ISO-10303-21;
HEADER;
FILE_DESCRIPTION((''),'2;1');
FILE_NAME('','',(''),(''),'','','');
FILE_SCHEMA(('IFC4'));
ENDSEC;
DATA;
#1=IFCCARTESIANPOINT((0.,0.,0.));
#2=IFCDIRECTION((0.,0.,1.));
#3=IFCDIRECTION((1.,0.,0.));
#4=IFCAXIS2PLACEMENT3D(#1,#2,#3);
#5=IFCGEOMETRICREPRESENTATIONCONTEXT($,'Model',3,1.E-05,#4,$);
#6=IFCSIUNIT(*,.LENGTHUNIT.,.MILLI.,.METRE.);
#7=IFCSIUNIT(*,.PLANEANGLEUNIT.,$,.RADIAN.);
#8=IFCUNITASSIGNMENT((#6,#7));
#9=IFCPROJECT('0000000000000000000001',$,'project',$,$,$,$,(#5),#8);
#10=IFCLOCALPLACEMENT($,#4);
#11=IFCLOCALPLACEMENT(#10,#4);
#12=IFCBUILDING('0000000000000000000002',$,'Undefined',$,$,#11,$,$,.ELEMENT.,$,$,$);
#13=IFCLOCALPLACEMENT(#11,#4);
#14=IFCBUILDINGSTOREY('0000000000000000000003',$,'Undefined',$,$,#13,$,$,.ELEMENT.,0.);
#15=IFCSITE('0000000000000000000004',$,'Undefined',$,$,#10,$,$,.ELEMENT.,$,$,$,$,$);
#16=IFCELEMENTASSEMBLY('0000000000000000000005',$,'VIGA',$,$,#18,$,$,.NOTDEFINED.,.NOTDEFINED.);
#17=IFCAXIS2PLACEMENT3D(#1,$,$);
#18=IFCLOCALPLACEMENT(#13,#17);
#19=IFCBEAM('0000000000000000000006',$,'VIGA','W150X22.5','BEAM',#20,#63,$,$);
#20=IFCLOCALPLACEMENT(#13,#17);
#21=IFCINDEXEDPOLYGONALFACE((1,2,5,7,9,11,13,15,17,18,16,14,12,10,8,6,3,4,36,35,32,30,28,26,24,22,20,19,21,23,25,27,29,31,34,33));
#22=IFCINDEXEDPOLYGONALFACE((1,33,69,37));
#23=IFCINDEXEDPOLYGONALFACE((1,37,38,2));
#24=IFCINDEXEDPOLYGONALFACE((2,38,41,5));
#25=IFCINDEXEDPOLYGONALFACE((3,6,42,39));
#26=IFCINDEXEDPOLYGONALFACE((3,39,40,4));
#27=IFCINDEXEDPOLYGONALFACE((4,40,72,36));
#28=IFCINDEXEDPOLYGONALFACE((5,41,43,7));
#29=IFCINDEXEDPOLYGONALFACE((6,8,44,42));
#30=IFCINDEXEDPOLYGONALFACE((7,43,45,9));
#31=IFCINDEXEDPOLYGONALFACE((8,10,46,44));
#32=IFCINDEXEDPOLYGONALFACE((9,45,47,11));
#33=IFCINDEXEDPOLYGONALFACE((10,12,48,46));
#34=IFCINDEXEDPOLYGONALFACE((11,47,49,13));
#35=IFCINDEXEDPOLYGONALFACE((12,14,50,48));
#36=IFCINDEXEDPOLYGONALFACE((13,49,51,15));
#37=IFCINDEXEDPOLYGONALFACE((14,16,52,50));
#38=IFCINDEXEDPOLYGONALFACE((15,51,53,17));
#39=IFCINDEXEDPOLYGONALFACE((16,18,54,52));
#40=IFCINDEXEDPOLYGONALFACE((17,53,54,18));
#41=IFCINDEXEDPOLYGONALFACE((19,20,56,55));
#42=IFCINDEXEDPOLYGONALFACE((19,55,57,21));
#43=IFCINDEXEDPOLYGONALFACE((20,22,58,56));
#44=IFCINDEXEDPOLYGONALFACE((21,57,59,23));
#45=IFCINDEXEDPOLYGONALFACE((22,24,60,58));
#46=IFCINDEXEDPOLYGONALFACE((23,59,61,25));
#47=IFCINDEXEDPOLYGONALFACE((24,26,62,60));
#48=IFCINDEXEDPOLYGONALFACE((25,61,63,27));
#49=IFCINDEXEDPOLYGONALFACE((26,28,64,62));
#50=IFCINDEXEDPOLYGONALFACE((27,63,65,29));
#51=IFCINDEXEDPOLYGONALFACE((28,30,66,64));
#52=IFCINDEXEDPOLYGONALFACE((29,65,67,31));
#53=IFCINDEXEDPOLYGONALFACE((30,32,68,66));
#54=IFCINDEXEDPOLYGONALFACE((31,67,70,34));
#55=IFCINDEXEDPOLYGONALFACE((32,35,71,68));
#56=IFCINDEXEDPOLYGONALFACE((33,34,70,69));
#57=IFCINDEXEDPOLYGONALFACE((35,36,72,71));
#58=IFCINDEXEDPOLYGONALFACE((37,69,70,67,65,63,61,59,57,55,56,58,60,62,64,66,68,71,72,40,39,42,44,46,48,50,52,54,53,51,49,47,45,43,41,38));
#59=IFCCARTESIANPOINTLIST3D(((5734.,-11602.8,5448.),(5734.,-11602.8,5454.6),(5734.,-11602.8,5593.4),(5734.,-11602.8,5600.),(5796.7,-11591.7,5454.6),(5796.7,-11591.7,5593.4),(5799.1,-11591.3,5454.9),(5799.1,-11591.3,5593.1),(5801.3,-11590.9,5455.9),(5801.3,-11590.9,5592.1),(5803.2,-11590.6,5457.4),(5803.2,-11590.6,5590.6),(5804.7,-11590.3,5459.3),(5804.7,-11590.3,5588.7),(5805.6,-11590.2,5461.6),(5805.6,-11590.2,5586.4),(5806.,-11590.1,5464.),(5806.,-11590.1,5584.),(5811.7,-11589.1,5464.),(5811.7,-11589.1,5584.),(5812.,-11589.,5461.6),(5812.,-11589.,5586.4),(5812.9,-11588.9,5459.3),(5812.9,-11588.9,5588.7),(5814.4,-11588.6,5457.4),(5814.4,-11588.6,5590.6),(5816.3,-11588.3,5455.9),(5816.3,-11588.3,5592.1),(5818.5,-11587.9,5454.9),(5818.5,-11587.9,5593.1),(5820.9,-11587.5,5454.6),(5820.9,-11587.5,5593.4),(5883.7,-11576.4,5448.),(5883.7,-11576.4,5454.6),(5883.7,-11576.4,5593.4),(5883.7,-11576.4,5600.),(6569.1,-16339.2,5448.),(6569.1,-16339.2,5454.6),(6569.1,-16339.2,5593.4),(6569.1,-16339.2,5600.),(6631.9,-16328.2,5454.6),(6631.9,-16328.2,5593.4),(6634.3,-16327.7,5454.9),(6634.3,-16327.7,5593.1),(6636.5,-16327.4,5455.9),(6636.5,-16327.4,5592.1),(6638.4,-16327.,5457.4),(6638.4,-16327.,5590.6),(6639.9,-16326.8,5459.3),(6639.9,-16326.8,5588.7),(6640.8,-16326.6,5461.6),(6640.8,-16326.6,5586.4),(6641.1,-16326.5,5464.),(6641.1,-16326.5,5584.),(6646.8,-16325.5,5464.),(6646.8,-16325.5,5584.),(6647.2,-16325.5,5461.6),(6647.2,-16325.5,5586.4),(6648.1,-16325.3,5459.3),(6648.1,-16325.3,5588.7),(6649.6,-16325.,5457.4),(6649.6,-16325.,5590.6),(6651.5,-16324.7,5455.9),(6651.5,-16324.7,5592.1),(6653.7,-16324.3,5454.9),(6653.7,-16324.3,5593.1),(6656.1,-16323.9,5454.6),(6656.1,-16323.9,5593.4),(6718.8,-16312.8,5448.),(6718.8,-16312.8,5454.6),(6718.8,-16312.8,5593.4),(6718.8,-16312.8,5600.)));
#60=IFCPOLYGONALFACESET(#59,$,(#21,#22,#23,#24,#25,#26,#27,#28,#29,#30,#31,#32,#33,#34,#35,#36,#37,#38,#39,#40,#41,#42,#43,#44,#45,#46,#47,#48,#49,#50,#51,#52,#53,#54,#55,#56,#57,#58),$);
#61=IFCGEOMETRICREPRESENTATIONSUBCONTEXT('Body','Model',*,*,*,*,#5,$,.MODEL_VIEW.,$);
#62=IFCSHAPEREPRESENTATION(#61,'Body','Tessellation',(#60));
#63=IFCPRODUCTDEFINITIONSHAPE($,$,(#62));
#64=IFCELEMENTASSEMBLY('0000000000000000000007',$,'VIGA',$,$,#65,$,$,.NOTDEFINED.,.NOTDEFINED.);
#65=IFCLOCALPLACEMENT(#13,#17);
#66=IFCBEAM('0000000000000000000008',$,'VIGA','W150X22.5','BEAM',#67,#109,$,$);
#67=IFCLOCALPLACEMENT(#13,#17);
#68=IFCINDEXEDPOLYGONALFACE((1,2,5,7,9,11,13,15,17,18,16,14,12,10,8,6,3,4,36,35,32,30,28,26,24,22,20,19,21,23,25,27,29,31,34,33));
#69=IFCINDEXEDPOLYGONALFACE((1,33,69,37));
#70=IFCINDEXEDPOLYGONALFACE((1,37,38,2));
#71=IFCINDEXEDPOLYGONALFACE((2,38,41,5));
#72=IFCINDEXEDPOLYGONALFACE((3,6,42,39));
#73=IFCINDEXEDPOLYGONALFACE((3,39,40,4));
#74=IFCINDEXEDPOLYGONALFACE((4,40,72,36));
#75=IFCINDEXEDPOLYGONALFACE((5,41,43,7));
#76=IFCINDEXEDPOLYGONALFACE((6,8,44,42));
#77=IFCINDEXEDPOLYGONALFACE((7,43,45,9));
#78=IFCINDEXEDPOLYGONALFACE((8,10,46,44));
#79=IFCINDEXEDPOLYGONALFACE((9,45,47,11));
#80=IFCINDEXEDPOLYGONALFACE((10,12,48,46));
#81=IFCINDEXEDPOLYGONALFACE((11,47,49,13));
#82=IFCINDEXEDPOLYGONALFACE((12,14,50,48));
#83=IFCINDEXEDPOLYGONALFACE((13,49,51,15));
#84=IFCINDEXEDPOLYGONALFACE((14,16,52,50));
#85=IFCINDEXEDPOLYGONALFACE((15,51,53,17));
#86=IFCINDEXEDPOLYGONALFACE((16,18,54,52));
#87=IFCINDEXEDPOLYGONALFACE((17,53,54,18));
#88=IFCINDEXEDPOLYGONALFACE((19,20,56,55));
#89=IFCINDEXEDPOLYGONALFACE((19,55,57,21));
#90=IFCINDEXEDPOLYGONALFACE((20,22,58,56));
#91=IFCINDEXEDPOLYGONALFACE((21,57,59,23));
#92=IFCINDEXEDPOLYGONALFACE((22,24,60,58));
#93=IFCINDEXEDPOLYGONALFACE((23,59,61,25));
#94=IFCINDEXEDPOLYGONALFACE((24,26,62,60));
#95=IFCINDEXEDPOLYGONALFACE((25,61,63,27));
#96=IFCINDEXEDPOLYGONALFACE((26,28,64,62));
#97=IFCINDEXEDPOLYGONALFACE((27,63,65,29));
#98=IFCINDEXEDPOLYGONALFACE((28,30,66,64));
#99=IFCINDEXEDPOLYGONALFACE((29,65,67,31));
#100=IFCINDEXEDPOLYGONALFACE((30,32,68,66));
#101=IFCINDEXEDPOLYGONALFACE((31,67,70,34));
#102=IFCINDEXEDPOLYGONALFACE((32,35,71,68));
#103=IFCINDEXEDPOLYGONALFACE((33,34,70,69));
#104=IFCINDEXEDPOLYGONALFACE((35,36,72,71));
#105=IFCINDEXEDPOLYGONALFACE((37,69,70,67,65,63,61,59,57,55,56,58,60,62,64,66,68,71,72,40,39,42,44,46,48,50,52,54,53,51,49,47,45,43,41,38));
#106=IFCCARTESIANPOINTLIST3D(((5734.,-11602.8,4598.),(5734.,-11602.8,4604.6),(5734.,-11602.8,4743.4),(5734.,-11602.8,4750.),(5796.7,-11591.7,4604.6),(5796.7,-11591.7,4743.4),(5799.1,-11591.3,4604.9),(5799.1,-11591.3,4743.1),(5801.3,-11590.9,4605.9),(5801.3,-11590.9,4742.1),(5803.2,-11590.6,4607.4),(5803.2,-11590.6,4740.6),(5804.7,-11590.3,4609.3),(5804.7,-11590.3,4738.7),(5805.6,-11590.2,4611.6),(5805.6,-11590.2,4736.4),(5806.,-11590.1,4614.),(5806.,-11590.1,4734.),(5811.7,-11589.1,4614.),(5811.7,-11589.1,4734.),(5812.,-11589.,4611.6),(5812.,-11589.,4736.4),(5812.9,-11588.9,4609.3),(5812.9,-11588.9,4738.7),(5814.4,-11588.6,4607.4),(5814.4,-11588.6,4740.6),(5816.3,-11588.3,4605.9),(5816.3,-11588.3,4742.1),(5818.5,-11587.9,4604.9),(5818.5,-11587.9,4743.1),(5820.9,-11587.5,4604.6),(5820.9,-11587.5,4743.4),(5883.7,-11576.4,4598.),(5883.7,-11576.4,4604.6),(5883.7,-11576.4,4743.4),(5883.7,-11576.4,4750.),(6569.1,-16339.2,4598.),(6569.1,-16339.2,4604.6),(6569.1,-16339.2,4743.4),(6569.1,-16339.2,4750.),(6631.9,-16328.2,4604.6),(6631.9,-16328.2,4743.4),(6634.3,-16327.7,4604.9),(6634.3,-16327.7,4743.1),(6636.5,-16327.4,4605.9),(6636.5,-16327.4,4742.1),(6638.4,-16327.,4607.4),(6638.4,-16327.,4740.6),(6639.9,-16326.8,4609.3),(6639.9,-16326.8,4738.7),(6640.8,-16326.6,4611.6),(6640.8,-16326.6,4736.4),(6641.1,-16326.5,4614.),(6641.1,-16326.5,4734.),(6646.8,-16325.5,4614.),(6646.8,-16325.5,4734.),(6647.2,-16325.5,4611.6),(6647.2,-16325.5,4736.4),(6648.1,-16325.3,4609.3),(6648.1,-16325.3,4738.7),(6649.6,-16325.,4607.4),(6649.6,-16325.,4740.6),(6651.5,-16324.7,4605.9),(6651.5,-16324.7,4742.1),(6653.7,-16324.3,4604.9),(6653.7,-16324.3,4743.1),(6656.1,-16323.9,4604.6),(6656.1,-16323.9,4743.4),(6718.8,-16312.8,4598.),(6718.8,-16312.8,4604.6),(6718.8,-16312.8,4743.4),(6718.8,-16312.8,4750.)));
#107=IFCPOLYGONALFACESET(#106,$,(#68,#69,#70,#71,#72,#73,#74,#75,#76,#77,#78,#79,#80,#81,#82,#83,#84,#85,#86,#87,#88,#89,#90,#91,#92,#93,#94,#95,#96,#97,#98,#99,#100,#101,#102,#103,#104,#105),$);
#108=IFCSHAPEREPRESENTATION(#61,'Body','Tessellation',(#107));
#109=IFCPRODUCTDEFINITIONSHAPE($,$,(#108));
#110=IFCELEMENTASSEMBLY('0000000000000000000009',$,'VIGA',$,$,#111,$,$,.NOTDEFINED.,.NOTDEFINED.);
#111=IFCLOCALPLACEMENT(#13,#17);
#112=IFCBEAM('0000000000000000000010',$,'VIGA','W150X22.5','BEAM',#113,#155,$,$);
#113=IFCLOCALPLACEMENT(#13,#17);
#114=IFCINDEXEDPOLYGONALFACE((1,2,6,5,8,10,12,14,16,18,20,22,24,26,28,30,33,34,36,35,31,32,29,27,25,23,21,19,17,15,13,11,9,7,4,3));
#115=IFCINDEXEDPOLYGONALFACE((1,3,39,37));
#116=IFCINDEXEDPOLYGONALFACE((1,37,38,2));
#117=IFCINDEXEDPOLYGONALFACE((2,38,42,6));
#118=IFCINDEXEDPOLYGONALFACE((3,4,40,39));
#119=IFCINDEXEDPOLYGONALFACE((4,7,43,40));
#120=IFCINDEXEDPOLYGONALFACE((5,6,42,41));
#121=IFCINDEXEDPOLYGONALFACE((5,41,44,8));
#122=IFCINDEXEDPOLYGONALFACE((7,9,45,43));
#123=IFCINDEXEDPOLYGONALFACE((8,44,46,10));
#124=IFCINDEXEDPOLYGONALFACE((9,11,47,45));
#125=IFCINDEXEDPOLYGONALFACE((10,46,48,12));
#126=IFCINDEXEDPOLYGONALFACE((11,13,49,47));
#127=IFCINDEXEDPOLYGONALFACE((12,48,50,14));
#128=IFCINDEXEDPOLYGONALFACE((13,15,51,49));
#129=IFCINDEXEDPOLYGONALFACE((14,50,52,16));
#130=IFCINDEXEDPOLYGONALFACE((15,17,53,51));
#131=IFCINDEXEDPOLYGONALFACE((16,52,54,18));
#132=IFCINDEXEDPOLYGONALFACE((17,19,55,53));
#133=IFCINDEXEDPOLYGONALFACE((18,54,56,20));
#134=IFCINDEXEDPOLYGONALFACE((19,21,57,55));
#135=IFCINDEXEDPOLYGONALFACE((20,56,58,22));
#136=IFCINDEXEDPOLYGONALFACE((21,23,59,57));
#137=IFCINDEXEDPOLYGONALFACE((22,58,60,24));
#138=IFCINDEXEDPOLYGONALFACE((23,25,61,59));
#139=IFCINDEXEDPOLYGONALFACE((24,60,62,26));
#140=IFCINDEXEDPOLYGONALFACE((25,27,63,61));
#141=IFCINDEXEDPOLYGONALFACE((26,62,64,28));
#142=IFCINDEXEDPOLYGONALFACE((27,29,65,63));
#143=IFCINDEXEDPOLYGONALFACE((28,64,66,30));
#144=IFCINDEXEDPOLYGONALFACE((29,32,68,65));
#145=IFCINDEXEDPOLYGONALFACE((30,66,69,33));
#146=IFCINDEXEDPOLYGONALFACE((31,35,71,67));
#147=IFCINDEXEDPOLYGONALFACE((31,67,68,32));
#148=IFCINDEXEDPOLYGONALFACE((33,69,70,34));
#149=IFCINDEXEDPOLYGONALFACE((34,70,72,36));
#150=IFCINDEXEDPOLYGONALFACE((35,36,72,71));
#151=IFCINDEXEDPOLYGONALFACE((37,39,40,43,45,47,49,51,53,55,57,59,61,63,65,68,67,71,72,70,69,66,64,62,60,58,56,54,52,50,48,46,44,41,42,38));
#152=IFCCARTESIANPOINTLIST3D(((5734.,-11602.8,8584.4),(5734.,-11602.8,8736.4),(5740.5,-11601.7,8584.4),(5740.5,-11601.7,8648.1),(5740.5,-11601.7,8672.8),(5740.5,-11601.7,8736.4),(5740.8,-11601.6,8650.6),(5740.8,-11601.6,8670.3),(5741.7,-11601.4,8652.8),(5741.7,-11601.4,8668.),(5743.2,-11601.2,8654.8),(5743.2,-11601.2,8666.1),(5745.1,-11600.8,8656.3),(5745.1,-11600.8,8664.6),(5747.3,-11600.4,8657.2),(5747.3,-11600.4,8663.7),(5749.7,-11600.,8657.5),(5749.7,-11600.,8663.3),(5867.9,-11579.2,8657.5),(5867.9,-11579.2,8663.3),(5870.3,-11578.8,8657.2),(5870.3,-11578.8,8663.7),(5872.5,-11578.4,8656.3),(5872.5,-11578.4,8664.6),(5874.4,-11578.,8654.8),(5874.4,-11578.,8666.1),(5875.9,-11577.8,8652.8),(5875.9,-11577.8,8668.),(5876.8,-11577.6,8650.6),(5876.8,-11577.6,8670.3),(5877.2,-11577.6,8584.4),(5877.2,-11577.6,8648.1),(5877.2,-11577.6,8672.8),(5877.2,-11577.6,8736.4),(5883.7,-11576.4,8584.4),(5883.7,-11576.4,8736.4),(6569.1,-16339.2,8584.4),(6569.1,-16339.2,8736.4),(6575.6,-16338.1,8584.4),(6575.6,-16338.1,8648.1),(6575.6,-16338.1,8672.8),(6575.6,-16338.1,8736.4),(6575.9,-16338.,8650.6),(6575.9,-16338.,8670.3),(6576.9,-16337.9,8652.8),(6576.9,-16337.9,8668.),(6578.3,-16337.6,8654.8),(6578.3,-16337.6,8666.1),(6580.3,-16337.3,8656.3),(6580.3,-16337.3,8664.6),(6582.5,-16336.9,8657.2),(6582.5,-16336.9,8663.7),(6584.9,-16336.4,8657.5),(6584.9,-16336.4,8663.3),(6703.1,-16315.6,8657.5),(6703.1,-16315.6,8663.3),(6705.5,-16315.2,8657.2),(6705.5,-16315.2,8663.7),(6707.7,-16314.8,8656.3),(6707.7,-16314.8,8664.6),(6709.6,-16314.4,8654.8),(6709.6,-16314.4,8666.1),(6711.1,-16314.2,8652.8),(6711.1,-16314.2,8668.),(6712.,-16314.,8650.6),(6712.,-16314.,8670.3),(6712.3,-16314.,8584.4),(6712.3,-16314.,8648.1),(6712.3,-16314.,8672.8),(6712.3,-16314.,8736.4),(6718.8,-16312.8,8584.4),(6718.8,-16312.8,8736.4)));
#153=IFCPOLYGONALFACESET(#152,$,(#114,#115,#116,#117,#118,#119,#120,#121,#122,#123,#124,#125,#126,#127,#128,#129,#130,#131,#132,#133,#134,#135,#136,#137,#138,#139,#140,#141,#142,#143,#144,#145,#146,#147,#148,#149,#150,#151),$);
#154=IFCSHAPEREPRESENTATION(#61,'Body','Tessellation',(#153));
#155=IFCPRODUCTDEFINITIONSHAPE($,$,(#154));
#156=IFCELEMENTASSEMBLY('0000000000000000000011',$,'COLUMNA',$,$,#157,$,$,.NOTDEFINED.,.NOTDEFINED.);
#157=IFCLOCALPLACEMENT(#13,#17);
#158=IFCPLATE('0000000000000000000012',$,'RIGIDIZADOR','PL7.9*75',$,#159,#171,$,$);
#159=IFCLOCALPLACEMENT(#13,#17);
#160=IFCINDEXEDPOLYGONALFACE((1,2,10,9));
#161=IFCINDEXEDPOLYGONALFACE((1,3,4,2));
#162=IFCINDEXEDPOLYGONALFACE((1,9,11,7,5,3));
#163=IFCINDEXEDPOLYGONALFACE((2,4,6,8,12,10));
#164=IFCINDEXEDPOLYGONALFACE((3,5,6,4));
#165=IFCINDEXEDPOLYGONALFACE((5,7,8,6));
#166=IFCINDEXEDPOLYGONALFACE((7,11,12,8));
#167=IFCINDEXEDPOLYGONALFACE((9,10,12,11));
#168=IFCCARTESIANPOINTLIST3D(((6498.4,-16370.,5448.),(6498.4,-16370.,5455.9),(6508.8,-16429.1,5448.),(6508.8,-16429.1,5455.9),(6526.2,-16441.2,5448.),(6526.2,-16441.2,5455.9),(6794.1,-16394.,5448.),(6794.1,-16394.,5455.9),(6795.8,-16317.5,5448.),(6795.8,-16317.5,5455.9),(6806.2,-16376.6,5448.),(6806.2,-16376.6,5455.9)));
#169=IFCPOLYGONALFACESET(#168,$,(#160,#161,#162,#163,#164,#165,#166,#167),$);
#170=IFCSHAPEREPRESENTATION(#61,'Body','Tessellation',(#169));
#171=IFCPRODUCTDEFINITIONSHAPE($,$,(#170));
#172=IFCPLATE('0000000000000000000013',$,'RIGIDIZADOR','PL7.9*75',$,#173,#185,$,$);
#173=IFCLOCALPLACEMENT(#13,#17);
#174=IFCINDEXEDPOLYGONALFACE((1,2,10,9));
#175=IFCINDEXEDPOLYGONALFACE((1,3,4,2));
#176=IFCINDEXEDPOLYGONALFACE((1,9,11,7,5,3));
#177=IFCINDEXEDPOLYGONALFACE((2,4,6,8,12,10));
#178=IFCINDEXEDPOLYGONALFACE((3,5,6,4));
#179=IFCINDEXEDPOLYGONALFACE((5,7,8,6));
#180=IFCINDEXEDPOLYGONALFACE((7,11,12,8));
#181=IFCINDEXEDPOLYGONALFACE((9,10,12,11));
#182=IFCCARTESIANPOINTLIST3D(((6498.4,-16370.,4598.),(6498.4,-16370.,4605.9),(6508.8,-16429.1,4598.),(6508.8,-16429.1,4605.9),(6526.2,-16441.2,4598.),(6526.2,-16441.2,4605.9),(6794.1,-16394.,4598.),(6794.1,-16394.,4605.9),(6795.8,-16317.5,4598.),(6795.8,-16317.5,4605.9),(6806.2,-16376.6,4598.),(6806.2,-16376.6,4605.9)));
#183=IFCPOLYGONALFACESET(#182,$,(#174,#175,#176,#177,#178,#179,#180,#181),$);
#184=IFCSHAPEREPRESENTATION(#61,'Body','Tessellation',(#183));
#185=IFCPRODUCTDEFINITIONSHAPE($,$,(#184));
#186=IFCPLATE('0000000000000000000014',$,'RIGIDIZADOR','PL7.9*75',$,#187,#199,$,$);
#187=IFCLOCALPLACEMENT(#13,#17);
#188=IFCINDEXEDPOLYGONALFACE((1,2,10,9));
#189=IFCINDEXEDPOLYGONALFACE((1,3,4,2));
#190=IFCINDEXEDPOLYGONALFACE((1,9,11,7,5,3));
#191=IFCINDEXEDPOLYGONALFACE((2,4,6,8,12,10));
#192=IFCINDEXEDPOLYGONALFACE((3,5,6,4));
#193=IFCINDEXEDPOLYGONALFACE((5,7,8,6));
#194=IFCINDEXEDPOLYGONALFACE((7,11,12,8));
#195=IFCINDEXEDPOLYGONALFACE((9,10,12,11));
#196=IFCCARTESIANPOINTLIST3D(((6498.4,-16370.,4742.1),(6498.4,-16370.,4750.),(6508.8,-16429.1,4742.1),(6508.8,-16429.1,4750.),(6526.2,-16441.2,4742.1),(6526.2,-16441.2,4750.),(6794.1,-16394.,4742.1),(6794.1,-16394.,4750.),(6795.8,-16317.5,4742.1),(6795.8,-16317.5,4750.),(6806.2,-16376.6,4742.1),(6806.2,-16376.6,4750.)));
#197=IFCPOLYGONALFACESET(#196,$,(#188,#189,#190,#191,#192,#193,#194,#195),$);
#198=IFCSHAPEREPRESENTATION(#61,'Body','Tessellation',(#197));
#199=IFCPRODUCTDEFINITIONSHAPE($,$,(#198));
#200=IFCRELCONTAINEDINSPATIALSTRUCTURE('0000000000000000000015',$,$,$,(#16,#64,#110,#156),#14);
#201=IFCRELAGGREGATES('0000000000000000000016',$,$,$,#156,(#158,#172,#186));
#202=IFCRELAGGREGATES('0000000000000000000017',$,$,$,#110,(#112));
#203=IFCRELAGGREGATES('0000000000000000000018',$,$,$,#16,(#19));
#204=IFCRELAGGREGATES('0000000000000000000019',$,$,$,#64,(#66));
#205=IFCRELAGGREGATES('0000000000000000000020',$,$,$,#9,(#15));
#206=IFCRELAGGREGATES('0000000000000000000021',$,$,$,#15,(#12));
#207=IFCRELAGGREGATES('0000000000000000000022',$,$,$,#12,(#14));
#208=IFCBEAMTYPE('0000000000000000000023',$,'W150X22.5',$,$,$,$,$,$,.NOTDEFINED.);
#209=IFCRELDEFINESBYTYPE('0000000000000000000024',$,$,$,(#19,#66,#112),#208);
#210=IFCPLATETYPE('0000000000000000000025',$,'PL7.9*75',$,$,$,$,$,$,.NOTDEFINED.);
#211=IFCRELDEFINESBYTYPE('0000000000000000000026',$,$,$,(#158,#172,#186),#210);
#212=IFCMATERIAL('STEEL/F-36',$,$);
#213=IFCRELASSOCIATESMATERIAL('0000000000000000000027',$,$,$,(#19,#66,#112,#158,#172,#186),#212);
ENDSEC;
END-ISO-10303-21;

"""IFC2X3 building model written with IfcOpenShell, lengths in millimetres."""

from ifc_helpers import new_model, si_unit, frame, origin_with_axes, origin_2d_with_axis, place, context, subcontext, project, spatial, polyline, i_section, outline, extrude, material, type_object, element, aggregate, save


model = new_model("IFC2X3")

# Units and contexts
model_context = context("Model", 3, precision=1e-05, world=origin_with_axes())
body_context = subcontext(model_context, "Body", "Model", "MODEL_VIEW")
ifc_project = project(units=[si_unit("LENGTHUNIT", "METRE", prefix="MILLI"), si_unit("PLANEANGLEUNIT", "RADIAN")], contexts=[model_context])

# Site, building, storey
site_placement = place(None, origin_with_axes())
site = spatial("IfcSite", under=ifc_project, at=site_placement, Name="Undefined", CompositionType="ELEMENT")
building_placement = place(site_placement, origin_with_axes())
building = spatial("IfcBuilding", under=site, at=building_placement, Name="Undefined", CompositionType="ELEMENT")
storey_placement = place(building_placement, origin_with_axes())
storey = spatial("IfcBuildingStorey", under=building, at=storey_placement, Name="Undefined", CompositionType="ELEMENT", Elevation=0.0)

# Shared definitions
ifc_material_1 = material(Name="STEEL/F-36")
beam_type_1 = type_object("IfcBeamType", Name="W150X22.5", PredefinedType="NOTDEFINED")

# Element assemblies, beams
assembly_1_placement = place(storey_placement, origin_with_axes())
assembly_1 = element("IfcElementAssembly", 1, at=assembly_1_placement, inside=storey, Name="VIGA", AssemblyPlace="NOTDEFINED", PredefinedType="NOTDEFINED")
beam_1_placement = place(assembly_1_placement, frame((6644.0, -16326.0, 5524.0), z_axis=(0.0, 0.0, 1.0), x_axis=(-0.173649, 0.984808, 0.0)))
beam_1 = element("IfcBeam", 2, at=beam_1_placement, type_object=beam_type_1, material=ifc_material_1, Name="VIGA", Description="W150X22.5", ObjectType="BEAM", context=body_context, shape_type="SweptSolid", body=[
    extrude(i_section(OverallWidth=152.0, OverallDepth=152.0, WebThickness=5.8, FlangeThickness=6.6, FilletRadius=9.4, at=origin_2d_with_axis()), frame((4809.5, 0.0, 0.0), z_axis=(-1.0, 0.0, 0.0), x_axis=(0.0, -1.0, 0.0)), (0.0, 0.0, 1.0), 4809.5),
])
assembly_2_placement = place(storey_placement, origin_with_axes())
assembly_2 = element("IfcElementAssembly", 3, at=assembly_2_placement, inside=storey, Name="VIGA", AssemblyPlace="NOTDEFINED", PredefinedType="NOTDEFINED")
beam_2_placement = place(assembly_2_placement, frame((6644.0, -16326.0, 4674.0), z_axis=(0.0, 0.0, 1.0), x_axis=(-0.173649, 0.984808, 0.0)))
beam_2 = element("IfcBeam", 4, at=beam_2_placement, type_object=beam_type_1, material=ifc_material_1, Name="VIGA", Description="W150X22.5", ObjectType="BEAM", context=body_context, shape_type="SweptSolid", body=[
    extrude(i_section(OverallWidth=152.0, OverallDepth=152.0, WebThickness=5.8, FlangeThickness=6.6, FilletRadius=9.4, at=origin_2d_with_axis()), frame((4809.5, 0.0, 0.0), z_axis=(-1.0, 0.0, 0.0), x_axis=(0.0, -1.0, 0.0)), (0.0, 0.0, 1.0), 4809.5),
])
assembly_3_placement = place(storey_placement, origin_with_axes())
assembly_3 = element("IfcElementAssembly", 5, at=assembly_3_placement, inside=storey, Name="VIGA", AssemblyPlace="NOTDEFINED", PredefinedType="NOTDEFINED")
beam_3_placement = place(assembly_3_placement, frame((6644.0, -16326.0, 8660.4), z_axis=(-0.984808, -0.173649, 0.0), x_axis=(-0.173649, 0.984808, 0.0)))
beam_3 = element("IfcBeam", 6, at=beam_3_placement, type_object=beam_type_1, material=ifc_material_1, Name="VIGA", Description="W150X22.5", ObjectType="BEAM", context=body_context, shape_type="SweptSolid", body=[
    extrude(i_section(OverallWidth=152.0, OverallDepth=152.0, WebThickness=5.8, FlangeThickness=6.6, FilletRadius=9.4, at=origin_2d_with_axis()), frame((4809.5, 0.0, 0.0), z_axis=(-1.0, 0.0, 0.0), x_axis=(0.0, -1.0, 0.0)), (0.0, 0.0, 1.0), 4809.5),
])

# Element assembly, plates
assembly_4_placement = place(storey_placement, origin_with_axes())
assembly_4 = element("IfcElementAssembly", 7, at=assembly_4_placement, inside=storey, Name="COLUMNA", AssemblyPlace="NOTDEFINED", PredefinedType="NOTDEFINED")
plate_type_1 = type_object("IfcPlateType", Name="PL7.9*75", PredefinedType="NOTDEFINED")
plate_1_placement = place(assembly_4_placement, frame((6808.8, -16391.4, 5451.9), z_axis=(0.0, 0.0, 1.0), x_axis=(-0.173649, 0.984808, 0.0)))
plate_1 = element("IfcPlate", 8, at=plate_1_placement, type_object=plate_type_1, material=ifc_material_1, Name="RIGIDIZADOR", Description="PL7.9*75", context=body_context, shape_type="SweptSolid", body=[
    extrude(outline(polyline([(0.0, 15.0), (15.0, 0.0), (75.0, 0.0), (75.0, 302.0), (15.0, 302.0), (0.0, 287.0), (0.0, 15.0)])), frame((0.0, 0.0, -4.0), z_axis=(0.0, 0.0, 1.0), x_axis=(1.0, 0.0, 0.0)), (0.0, 0.0, 1.0), 7.9),
])
plate_2_placement = place(assembly_4_placement, frame((6808.8, -16391.4, 4601.9), z_axis=(0.0, 0.0, 1.0), x_axis=(-0.173649, 0.984808, 0.0)))
plate_2 = element("IfcPlate", 9, at=plate_2_placement, type_object=plate_type_1, material=ifc_material_1, Name="RIGIDIZADOR", Description="PL7.9*75", context=body_context, shape_type="SweptSolid", body=[
    extrude(outline(polyline([(0.0, 15.0), (15.0, 0.0), (75.0, 0.0), (75.0, 302.0), (15.0, 302.0), (0.0, 287.0), (0.0, 15.0)])), frame((0.0, 0.0, -4.0), z_axis=(0.0, 0.0, 1.0), x_axis=(1.0, 0.0, 0.0)), (0.0, 0.0, 1.0), 7.9),
])
plate_3_placement = place(assembly_4_placement, frame((6808.8, -16391.4, 4746.1), z_axis=(0.0, 0.0, 1.0), x_axis=(-0.173649, 0.984808, 0.0)))
plate_3 = element("IfcPlate", 10, at=plate_3_placement, type_object=plate_type_1, material=ifc_material_1, Name="RIGIDIZADOR", Description="PL7.9*75", context=body_context, shape_type="SweptSolid", body=[
    extrude(outline(polyline([(0.0, 15.0), (15.0, 0.0), (75.0, 0.0), (75.0, 302.0), (15.0, 302.0), (0.0, 287.0), (0.0, 15.0)])), frame((0.0, 0.0, -4.0), z_axis=(0.0, 0.0, 1.0), x_axis=(1.0, 0.0, 0.0)), (0.0, 0.0, 1.0), 7.9),
])

aggregate(assembly_4, [plate_1, plate_2, plate_3])

aggregate(assembly_3, [beam_3])
aggregate(assembly_1, [beam_1])
aggregate(assembly_2, [beam_2])

save(model, "model.ifc")
